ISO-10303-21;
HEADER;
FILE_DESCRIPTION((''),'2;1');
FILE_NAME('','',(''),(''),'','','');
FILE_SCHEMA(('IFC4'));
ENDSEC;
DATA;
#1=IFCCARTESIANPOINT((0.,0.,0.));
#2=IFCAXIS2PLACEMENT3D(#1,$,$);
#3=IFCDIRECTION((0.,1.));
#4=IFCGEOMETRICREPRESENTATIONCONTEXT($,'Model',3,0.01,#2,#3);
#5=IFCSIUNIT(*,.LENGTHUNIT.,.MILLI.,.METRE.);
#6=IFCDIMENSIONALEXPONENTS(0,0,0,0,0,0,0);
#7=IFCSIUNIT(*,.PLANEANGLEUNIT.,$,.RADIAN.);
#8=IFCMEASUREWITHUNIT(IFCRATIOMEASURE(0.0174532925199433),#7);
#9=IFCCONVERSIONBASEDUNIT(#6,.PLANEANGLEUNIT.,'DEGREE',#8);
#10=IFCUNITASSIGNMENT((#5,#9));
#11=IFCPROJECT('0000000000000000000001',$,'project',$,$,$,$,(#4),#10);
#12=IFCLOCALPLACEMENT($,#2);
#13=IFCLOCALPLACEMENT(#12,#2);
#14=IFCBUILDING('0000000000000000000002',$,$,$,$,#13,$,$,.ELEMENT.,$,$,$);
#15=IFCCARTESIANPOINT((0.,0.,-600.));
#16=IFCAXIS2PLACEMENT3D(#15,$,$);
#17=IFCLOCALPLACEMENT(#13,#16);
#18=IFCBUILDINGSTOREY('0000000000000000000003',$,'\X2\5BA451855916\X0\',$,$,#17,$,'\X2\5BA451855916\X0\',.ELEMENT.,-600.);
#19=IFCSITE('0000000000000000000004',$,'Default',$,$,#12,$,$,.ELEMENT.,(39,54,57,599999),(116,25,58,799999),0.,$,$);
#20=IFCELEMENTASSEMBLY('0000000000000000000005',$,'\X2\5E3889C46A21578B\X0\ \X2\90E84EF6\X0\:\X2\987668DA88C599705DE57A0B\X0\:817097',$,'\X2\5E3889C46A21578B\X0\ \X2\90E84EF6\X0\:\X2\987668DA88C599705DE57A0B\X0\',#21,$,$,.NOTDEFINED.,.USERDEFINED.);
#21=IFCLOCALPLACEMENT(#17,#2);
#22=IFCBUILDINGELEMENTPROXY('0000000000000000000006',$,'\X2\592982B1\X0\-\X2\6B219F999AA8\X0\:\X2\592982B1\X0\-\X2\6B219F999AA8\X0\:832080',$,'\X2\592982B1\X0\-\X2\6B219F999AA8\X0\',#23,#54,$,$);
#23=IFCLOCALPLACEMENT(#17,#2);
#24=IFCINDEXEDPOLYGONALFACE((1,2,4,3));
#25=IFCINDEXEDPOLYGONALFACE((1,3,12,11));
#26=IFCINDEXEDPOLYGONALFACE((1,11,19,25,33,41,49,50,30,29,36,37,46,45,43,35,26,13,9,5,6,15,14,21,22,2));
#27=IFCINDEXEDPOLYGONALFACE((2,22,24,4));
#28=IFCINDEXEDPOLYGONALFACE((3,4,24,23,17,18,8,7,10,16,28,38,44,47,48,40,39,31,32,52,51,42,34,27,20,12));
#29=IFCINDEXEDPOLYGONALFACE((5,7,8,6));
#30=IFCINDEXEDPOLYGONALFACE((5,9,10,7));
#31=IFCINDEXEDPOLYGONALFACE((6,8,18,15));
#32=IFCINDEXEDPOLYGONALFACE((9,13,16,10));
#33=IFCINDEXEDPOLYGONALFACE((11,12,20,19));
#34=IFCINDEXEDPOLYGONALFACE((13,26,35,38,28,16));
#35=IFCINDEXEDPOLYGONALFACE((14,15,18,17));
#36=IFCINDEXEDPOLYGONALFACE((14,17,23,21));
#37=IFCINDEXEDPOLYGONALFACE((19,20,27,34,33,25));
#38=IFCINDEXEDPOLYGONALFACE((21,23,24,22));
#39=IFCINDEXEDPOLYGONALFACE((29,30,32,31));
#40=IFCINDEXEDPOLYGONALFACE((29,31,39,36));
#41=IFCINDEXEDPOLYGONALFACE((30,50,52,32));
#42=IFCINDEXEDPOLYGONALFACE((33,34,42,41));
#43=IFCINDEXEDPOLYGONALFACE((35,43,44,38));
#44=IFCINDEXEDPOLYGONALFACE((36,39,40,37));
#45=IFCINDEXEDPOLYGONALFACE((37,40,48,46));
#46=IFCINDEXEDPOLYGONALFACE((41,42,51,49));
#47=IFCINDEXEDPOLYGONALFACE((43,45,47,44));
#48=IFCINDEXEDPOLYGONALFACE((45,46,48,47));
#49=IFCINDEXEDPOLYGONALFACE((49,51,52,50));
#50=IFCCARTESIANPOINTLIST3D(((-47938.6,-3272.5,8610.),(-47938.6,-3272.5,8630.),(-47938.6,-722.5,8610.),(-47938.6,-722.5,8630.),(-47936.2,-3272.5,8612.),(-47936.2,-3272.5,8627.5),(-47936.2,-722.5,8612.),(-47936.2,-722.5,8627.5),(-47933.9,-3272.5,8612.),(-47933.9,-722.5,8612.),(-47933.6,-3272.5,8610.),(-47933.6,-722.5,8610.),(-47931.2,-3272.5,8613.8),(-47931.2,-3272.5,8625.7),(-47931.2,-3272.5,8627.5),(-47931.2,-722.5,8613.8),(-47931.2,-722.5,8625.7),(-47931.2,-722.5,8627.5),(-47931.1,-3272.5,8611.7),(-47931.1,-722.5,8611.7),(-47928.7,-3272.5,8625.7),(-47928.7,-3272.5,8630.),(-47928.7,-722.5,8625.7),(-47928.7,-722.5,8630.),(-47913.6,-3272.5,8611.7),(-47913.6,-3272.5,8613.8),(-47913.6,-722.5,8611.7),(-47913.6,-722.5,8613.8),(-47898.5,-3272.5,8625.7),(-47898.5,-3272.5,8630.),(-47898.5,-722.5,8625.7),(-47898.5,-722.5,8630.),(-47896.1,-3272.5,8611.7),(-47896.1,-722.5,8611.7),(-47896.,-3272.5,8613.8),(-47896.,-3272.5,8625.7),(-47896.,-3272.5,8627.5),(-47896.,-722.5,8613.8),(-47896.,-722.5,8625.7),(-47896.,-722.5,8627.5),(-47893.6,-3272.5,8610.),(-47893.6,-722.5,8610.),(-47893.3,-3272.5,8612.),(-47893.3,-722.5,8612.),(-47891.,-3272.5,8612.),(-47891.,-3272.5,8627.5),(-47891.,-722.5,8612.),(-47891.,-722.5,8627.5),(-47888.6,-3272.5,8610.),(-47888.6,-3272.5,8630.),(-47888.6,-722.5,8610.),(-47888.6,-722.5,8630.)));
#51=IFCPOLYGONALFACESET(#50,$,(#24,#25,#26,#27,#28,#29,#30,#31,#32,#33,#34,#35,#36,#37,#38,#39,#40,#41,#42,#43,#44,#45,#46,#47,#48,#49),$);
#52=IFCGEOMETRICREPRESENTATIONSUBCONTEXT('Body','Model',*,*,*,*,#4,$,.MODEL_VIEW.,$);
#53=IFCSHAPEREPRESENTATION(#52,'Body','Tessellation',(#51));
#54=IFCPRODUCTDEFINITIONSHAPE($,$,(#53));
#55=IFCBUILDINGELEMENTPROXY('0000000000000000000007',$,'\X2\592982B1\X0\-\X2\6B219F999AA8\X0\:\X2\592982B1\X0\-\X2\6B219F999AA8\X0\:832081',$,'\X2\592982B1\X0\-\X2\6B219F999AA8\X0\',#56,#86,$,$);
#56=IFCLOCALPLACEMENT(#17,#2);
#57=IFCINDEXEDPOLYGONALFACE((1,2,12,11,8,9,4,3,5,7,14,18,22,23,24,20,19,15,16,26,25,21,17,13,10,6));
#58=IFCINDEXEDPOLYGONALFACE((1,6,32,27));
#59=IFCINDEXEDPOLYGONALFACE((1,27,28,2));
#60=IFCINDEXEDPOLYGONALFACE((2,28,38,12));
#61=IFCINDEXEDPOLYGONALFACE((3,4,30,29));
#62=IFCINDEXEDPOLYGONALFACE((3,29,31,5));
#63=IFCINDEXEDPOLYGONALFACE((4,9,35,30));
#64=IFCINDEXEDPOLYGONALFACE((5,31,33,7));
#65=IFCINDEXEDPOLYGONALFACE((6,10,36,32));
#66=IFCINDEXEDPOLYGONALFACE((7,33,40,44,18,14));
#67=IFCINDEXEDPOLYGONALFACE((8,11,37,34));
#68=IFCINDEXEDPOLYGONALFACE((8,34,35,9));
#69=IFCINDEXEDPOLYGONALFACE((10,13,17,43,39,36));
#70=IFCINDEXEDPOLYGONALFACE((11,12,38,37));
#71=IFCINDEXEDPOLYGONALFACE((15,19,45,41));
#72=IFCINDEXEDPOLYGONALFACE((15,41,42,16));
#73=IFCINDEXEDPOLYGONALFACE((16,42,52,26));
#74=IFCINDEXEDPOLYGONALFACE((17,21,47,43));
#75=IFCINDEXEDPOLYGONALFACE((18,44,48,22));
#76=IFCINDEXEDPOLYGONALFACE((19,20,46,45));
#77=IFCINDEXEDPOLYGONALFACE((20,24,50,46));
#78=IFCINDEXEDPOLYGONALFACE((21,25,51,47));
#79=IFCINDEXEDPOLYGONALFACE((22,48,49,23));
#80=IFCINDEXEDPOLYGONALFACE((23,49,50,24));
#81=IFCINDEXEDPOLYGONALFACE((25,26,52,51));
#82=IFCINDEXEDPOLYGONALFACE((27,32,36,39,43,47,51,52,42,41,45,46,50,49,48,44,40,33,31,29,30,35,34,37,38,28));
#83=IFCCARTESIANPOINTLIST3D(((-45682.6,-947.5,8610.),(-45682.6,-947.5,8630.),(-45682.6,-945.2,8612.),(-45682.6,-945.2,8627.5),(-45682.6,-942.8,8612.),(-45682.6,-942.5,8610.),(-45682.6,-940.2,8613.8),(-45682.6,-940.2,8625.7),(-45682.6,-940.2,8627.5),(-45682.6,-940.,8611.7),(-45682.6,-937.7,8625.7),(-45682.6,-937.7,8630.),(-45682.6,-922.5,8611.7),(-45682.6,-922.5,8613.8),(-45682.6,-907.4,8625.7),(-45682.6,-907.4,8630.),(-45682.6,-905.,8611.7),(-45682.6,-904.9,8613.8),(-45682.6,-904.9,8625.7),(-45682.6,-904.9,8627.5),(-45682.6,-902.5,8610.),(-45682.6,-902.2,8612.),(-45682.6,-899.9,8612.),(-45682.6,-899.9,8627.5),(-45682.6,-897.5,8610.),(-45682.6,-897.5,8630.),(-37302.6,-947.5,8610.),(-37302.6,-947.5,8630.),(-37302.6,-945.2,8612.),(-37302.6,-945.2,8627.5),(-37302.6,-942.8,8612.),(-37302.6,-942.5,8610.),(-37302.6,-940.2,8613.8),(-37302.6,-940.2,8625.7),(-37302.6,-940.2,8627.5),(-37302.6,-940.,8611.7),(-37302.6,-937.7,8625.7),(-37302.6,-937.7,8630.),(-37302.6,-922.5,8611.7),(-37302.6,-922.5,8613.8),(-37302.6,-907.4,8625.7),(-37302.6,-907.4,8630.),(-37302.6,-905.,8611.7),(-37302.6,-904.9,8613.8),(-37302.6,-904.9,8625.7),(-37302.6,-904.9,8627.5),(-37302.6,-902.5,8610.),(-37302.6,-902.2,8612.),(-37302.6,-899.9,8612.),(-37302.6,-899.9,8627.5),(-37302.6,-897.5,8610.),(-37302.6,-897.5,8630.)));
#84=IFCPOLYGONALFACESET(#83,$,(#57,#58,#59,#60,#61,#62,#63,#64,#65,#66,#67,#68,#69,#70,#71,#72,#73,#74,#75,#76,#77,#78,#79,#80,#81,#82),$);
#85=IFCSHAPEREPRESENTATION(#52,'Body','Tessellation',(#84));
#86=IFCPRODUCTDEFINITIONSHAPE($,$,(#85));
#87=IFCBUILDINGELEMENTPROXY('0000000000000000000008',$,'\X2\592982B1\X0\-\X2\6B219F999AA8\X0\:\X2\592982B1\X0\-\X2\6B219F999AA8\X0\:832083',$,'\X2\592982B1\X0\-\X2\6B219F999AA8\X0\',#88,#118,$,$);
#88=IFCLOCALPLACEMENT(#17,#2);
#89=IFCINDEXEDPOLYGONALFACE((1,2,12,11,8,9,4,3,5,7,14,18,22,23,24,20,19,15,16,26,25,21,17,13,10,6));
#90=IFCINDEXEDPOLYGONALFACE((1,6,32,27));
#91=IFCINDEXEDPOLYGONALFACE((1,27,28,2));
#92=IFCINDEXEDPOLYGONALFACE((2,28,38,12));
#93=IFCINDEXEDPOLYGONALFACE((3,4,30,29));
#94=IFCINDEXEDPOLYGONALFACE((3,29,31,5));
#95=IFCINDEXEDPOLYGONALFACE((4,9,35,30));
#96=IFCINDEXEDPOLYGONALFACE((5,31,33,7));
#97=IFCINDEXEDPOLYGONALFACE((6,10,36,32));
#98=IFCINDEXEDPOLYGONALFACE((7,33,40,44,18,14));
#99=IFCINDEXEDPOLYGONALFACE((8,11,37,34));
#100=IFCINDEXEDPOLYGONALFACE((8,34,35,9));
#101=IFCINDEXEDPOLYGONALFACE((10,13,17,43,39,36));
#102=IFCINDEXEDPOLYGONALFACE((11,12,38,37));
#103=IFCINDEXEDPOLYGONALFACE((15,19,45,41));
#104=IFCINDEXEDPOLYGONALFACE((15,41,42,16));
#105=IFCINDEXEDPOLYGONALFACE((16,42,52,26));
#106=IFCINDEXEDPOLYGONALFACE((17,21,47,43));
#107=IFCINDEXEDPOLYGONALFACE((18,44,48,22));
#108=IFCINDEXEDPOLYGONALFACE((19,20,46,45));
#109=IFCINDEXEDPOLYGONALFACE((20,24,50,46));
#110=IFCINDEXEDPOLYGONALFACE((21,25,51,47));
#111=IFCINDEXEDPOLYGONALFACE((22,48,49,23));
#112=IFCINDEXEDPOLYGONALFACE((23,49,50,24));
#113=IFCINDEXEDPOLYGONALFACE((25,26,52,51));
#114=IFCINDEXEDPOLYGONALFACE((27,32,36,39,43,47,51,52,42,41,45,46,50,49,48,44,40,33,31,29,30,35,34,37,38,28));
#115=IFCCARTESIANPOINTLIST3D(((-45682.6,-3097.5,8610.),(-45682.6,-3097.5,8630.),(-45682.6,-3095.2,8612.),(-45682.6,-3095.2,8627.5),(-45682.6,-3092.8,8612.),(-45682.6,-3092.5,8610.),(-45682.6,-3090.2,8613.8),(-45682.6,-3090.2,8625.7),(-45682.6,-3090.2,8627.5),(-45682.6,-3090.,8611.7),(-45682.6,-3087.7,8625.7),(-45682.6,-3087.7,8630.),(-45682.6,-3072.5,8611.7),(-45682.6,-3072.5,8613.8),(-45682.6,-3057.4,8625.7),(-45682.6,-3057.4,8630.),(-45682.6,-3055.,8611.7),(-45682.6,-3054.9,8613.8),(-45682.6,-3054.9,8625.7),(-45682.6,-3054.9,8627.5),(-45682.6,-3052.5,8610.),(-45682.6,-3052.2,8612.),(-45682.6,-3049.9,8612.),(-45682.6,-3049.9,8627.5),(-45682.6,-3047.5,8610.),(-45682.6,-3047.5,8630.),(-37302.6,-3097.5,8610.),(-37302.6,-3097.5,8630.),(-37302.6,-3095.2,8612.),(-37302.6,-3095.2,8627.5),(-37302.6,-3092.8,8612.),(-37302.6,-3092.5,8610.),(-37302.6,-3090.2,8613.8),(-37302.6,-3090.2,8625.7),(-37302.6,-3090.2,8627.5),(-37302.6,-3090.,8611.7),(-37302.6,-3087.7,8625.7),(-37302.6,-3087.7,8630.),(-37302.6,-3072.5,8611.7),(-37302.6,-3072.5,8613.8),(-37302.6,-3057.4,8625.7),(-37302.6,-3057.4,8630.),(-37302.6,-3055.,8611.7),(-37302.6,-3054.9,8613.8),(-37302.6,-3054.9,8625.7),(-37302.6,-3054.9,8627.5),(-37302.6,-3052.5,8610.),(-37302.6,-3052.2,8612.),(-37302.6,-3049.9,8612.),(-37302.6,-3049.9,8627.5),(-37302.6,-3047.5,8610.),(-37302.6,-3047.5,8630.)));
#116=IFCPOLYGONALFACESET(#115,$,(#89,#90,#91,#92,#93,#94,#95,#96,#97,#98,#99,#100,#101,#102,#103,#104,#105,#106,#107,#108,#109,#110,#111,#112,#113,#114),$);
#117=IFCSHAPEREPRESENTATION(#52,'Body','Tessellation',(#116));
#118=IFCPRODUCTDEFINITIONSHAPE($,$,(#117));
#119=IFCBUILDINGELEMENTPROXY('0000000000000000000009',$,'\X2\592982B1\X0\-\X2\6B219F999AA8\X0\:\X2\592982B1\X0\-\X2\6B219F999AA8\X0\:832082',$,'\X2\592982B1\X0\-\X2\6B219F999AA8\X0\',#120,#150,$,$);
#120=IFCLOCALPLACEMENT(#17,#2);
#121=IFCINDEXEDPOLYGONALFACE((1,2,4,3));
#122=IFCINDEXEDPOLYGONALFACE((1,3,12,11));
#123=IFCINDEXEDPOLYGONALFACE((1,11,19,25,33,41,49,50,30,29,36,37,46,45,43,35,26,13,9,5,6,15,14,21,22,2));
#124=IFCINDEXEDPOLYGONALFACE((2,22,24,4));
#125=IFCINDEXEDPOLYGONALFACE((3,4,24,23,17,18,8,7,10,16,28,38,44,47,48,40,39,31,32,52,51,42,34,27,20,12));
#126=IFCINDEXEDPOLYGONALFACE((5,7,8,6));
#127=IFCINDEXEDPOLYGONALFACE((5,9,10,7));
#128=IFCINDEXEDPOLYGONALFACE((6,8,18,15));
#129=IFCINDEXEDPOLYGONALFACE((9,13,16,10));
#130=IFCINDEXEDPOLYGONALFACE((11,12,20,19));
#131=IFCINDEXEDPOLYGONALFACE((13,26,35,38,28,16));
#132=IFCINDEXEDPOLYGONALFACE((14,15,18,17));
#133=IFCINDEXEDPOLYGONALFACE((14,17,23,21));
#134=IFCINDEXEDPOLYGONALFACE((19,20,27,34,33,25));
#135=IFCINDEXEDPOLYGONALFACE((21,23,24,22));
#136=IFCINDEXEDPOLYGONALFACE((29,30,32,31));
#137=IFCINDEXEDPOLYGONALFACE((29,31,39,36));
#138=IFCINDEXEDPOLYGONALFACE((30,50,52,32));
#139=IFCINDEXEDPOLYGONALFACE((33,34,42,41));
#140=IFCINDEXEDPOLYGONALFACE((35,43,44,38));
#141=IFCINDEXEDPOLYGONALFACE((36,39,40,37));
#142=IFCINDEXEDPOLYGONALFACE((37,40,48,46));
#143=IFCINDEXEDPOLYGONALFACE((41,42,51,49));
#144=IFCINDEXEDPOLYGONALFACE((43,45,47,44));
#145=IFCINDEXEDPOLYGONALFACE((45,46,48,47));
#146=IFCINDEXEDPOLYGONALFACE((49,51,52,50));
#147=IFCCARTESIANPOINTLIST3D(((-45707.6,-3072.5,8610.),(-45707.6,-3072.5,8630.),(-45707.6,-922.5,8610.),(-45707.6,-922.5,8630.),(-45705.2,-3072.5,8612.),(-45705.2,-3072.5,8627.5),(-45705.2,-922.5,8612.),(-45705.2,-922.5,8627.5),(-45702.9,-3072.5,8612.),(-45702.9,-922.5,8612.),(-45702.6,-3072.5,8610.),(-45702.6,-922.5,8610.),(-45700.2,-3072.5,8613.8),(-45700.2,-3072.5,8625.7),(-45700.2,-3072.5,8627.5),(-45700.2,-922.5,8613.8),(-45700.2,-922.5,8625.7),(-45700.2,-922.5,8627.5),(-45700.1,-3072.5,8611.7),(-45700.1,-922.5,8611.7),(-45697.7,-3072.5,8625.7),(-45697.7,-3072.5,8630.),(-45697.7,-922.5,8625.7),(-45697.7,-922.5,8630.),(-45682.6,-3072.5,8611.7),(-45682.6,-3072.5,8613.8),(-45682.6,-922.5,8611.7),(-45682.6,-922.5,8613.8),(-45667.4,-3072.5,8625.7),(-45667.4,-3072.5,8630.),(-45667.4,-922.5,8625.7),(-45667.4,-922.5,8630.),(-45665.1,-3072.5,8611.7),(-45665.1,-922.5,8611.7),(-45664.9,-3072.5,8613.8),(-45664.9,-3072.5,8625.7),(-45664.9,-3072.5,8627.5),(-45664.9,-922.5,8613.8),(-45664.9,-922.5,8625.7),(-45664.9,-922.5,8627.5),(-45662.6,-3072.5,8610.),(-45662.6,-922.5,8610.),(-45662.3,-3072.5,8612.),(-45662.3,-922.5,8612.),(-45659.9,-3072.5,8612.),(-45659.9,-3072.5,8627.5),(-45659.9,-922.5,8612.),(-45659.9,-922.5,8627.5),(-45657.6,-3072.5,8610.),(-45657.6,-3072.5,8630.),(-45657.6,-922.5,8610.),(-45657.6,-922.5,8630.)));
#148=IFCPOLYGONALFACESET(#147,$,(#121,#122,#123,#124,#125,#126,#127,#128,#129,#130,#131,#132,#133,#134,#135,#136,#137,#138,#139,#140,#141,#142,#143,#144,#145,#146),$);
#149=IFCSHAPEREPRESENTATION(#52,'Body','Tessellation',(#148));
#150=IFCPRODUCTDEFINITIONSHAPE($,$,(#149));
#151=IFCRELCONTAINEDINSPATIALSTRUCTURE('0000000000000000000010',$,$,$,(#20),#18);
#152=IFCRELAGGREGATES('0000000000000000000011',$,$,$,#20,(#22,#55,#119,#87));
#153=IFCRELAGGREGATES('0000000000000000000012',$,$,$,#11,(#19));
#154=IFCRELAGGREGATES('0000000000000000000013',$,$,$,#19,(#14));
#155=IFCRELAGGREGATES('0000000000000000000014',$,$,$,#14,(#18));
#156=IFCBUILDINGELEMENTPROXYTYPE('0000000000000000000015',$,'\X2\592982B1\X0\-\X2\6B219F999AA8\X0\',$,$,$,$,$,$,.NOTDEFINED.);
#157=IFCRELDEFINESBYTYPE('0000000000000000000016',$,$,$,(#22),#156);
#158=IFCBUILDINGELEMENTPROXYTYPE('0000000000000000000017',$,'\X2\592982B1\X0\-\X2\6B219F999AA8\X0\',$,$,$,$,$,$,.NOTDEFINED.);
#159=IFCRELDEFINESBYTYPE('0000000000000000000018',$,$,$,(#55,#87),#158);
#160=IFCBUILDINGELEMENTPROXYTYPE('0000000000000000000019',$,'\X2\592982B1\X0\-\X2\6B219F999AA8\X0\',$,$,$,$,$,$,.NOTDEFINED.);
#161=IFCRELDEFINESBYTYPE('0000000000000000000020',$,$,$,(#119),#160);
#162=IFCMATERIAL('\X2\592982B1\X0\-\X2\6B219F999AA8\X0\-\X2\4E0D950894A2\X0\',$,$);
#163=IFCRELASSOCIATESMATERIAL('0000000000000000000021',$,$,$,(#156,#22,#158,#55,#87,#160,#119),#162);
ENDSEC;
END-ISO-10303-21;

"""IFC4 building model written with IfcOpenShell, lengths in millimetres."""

from ifc_helpers import new_model, entity, si_unit, converted_unit, direction, frame, origin, place, context, subcontext, project, spatial, polyline, outline, extrude, source, transform, mapped, material, type_object, type_shapes, element, aggregate, save


model = new_model("IFC4")

# Units and contexts
model_context = context("Model", 3, precision=0.01, world=origin(), true_north=direction((0.0, 1.0)))
body_context = subcontext(model_context, "Body", "Model", "MODEL_VIEW")
ifc_project = project(units=[si_unit("LENGTHUNIT", "METRE", prefix="MILLI"), converted_unit("PLANEANGLEUNIT", "DEGREE", entity("IfcRatioMeasure", 0.0174532925199433), si_unit("PLANEANGLEUNIT", "RADIAN"), dimensions=[0, 0, 0, 0, 0, 0, 0])], contexts=[model_context])

# Site, building, storey
site_placement = place(None, origin())
site = spatial("IfcSite", under=ifc_project, at=site_placement, Name="Default", CompositionType="ELEMENT", RefLatitude=(39, 54, 57, 599999), RefLongitude=(116, 25, 58, 799999), RefElevation=0.0)
building_placement = place(site_placement, origin())
building = spatial("IfcBuilding", under=site, at=building_placement, CompositionType="ELEMENT")
storey_placement = place(building_placement, frame((0.0, 0.0, -600.0)))
storey = spatial("IfcBuildingStorey", under=building, at=storey_placement, Name="室内外", LongName="室内外", CompositionType="ELEMENT", Elevation=-600.0)

# Element assembly, building element proxies
assembly_1_placement = place(storey_placement, origin())
assembly_1 = element("IfcElementAssembly", 1, at=assembly_1_placement, inside=storey, Name="常规模型 部件:顶棚装饰工程:817097", ObjectType="常规模型 部件:顶棚装饰工程", AssemblyPlace="NOTDEFINED", PredefinedType="USERDEFINED")
ifc_material_1 = material(Name="天花-次龙骨-不锈钢")
building_element_proxy_type_1 = type_object("IfcBuildingElementProxyType", Name="天花-次龙骨", PredefinedType="NOTDEFINED", material=ifc_material_1)
shared_shape_1 = source(origin(), body_context, "Body", "SweptSolid", [
    extrude(outline(polyline([(-25.0, -9.1), (-20.0, -9.1), (-17.5, -7.4), (0.0, -7.4), (17.5, -7.4), (20.0, -9.1), (25.0, -9.1), (25.0, 10.9), (15.1, 10.9), (15.1, 6.6), (17.6, 6.6), (17.6, 8.4), (22.6, 8.4), (22.6, -7.1), (20.3, -7.1), (17.6, -5.3), (0.0, -5.3), (-17.6, -5.3), (-20.3, -7.1), (-22.6, -7.1), (-22.6, 8.4), (-17.6, 8.4), (-17.6, 6.6), (-15.1, 6.6), (-15.1, 10.9), (-25.0, 10.9), (-25.0, -9.1)])), frame((0.0, 0.0, -0.9), z_axis=(1.0, 0.0, 0.0), x_axis=(0.0, 1.0, 0.0)), (0.0, 0.0, 1.0), 2550.0),
])
type_shapes(building_element_proxy_type_1, [shared_shape_1])
proxy_1_placement = place(assembly_1_placement, frame((-47913.6, -722.5, 8620.0), z_axis=(0.0, 0.0, 1.0), x_axis=(0.0, -1.0, 0.0)))
proxy_1 = element("IfcBuildingElementProxy", 2, at=proxy_1_placement, type_object=building_element_proxy_type_1, material=ifc_material_1, Name="天花-次龙骨:天花-次龙骨:832080", ObjectType="天花-次龙骨", context=body_context, shape_type="MappedRepresentation", body=[
    mapped(shared_shape_1, transform((0.0, 0.0, 0.0), scale=1.0)),
])
building_element_proxy_type_2 = type_object("IfcBuildingElementProxyType", Name="天花-次龙骨", PredefinedType="NOTDEFINED", material=ifc_material_1)
shared_shape_2 = source(origin(), body_context, "Body", "SweptSolid", [
    extrude(outline(polyline([(-25.0, -9.1), (-20.0, -9.1), (-17.5, -7.4), (0.0, -7.4), (17.5, -7.4), (20.0, -9.1), (25.0, -9.1), (25.0, 10.9), (15.1, 10.9), (15.1, 6.6), (17.6, 6.6), (17.6, 8.4), (22.6, 8.4), (22.6, -7.1), (20.3, -7.1), (17.6, -5.3), (0.0, -5.3), (-17.6, -5.3), (-20.3, -7.1), (-22.6, -7.1), (-22.6, 8.4), (-17.6, 8.4), (-17.6, 6.6), (-15.1, 6.6), (-15.1, 10.9), (-25.0, 10.9), (-25.0, -9.1)])), frame((0.0, 0.0, -0.9), z_axis=(1.0, 0.0, 0.0), x_axis=(0.0, 1.0, 0.0)), (0.0, 0.0, 1.0), 8380.0),
])
type_shapes(building_element_proxy_type_2, [shared_shape_2])
proxy_2_placement = place(assembly_1_placement, frame((-45682.6, -922.5, 8620.0)))
proxy_2 = element("IfcBuildingElementProxy", 3, at=proxy_2_placement, type_object=building_element_proxy_type_2, material=ifc_material_1, Name="天花-次龙骨:天花-次龙骨:832081", ObjectType="天花-次龙骨", context=body_context, shape_type="MappedRepresentation", body=[
    mapped(shared_shape_2, transform((0.0, 0.0, 0.0), scale=1.0)),
])
proxy_3_placement = place(assembly_1_placement, frame((-45682.6, -3072.5, 8620.0)))
proxy_3 = element("IfcBuildingElementProxy", 4, at=proxy_3_placement, type_object=building_element_proxy_type_2, material=ifc_material_1, Name="天花-次龙骨:天花-次龙骨:832083", ObjectType="天花-次龙骨", context=body_context, shape_type="MappedRepresentation", body=[
    mapped(shared_shape_2, transform((0.0, 0.0, 0.0), scale=1.0)),
])
building_element_proxy_type_3 = type_object("IfcBuildingElementProxyType", Name="天花-次龙骨", PredefinedType="NOTDEFINED", material=ifc_material_1)
shared_shape_3 = source(origin(), body_context, "Body", "SweptSolid", [
    extrude(outline(polyline([(-25.0, -9.1), (-20.0, -9.1), (-17.5, -7.4), (0.0, -7.4), (17.5, -7.4), (20.0, -9.1), (25.0, -9.1), (25.0, 10.9), (15.1, 10.9), (15.1, 6.6), (17.6, 6.6), (17.6, 8.4), (22.6, 8.4), (22.6, -7.1), (20.3, -7.1), (17.6, -5.3), (0.0, -5.3), (-17.6, -5.3), (-20.3, -7.1), (-22.6, -7.1), (-22.6, 8.4), (-17.6, 8.4), (-17.6, 6.6), (-15.1, 6.6), (-15.1, 10.9), (-25.0, 10.9), (-25.0, -9.1)])), frame((0.0, 0.0, -0.9), z_axis=(1.0, 0.0, 0.0), x_axis=(0.0, 1.0, 0.0)), (0.0, 0.0, 1.0), 2150.0),
])
type_shapes(building_element_proxy_type_3, [shared_shape_3])
proxy_4_placement = place(assembly_1_placement, frame((-45682.6, -922.5, 8620.0), z_axis=(0.0, 0.0, 1.0), x_axis=(0.0, -1.0, 0.0)))
proxy_4 = element("IfcBuildingElementProxy", 5, at=proxy_4_placement, type_object=building_element_proxy_type_3, material=ifc_material_1, Name="天花-次龙骨:天花-次龙骨:832082", ObjectType="天花-次龙骨", context=body_context, shape_type="MappedRepresentation", body=[
    mapped(shared_shape_3, transform((0.0, 0.0, 0.0), scale=1.0)),
])
aggregate(assembly_1, [proxy_1, proxy_2, proxy_4, proxy_3])

save(model, "model.ifc")
